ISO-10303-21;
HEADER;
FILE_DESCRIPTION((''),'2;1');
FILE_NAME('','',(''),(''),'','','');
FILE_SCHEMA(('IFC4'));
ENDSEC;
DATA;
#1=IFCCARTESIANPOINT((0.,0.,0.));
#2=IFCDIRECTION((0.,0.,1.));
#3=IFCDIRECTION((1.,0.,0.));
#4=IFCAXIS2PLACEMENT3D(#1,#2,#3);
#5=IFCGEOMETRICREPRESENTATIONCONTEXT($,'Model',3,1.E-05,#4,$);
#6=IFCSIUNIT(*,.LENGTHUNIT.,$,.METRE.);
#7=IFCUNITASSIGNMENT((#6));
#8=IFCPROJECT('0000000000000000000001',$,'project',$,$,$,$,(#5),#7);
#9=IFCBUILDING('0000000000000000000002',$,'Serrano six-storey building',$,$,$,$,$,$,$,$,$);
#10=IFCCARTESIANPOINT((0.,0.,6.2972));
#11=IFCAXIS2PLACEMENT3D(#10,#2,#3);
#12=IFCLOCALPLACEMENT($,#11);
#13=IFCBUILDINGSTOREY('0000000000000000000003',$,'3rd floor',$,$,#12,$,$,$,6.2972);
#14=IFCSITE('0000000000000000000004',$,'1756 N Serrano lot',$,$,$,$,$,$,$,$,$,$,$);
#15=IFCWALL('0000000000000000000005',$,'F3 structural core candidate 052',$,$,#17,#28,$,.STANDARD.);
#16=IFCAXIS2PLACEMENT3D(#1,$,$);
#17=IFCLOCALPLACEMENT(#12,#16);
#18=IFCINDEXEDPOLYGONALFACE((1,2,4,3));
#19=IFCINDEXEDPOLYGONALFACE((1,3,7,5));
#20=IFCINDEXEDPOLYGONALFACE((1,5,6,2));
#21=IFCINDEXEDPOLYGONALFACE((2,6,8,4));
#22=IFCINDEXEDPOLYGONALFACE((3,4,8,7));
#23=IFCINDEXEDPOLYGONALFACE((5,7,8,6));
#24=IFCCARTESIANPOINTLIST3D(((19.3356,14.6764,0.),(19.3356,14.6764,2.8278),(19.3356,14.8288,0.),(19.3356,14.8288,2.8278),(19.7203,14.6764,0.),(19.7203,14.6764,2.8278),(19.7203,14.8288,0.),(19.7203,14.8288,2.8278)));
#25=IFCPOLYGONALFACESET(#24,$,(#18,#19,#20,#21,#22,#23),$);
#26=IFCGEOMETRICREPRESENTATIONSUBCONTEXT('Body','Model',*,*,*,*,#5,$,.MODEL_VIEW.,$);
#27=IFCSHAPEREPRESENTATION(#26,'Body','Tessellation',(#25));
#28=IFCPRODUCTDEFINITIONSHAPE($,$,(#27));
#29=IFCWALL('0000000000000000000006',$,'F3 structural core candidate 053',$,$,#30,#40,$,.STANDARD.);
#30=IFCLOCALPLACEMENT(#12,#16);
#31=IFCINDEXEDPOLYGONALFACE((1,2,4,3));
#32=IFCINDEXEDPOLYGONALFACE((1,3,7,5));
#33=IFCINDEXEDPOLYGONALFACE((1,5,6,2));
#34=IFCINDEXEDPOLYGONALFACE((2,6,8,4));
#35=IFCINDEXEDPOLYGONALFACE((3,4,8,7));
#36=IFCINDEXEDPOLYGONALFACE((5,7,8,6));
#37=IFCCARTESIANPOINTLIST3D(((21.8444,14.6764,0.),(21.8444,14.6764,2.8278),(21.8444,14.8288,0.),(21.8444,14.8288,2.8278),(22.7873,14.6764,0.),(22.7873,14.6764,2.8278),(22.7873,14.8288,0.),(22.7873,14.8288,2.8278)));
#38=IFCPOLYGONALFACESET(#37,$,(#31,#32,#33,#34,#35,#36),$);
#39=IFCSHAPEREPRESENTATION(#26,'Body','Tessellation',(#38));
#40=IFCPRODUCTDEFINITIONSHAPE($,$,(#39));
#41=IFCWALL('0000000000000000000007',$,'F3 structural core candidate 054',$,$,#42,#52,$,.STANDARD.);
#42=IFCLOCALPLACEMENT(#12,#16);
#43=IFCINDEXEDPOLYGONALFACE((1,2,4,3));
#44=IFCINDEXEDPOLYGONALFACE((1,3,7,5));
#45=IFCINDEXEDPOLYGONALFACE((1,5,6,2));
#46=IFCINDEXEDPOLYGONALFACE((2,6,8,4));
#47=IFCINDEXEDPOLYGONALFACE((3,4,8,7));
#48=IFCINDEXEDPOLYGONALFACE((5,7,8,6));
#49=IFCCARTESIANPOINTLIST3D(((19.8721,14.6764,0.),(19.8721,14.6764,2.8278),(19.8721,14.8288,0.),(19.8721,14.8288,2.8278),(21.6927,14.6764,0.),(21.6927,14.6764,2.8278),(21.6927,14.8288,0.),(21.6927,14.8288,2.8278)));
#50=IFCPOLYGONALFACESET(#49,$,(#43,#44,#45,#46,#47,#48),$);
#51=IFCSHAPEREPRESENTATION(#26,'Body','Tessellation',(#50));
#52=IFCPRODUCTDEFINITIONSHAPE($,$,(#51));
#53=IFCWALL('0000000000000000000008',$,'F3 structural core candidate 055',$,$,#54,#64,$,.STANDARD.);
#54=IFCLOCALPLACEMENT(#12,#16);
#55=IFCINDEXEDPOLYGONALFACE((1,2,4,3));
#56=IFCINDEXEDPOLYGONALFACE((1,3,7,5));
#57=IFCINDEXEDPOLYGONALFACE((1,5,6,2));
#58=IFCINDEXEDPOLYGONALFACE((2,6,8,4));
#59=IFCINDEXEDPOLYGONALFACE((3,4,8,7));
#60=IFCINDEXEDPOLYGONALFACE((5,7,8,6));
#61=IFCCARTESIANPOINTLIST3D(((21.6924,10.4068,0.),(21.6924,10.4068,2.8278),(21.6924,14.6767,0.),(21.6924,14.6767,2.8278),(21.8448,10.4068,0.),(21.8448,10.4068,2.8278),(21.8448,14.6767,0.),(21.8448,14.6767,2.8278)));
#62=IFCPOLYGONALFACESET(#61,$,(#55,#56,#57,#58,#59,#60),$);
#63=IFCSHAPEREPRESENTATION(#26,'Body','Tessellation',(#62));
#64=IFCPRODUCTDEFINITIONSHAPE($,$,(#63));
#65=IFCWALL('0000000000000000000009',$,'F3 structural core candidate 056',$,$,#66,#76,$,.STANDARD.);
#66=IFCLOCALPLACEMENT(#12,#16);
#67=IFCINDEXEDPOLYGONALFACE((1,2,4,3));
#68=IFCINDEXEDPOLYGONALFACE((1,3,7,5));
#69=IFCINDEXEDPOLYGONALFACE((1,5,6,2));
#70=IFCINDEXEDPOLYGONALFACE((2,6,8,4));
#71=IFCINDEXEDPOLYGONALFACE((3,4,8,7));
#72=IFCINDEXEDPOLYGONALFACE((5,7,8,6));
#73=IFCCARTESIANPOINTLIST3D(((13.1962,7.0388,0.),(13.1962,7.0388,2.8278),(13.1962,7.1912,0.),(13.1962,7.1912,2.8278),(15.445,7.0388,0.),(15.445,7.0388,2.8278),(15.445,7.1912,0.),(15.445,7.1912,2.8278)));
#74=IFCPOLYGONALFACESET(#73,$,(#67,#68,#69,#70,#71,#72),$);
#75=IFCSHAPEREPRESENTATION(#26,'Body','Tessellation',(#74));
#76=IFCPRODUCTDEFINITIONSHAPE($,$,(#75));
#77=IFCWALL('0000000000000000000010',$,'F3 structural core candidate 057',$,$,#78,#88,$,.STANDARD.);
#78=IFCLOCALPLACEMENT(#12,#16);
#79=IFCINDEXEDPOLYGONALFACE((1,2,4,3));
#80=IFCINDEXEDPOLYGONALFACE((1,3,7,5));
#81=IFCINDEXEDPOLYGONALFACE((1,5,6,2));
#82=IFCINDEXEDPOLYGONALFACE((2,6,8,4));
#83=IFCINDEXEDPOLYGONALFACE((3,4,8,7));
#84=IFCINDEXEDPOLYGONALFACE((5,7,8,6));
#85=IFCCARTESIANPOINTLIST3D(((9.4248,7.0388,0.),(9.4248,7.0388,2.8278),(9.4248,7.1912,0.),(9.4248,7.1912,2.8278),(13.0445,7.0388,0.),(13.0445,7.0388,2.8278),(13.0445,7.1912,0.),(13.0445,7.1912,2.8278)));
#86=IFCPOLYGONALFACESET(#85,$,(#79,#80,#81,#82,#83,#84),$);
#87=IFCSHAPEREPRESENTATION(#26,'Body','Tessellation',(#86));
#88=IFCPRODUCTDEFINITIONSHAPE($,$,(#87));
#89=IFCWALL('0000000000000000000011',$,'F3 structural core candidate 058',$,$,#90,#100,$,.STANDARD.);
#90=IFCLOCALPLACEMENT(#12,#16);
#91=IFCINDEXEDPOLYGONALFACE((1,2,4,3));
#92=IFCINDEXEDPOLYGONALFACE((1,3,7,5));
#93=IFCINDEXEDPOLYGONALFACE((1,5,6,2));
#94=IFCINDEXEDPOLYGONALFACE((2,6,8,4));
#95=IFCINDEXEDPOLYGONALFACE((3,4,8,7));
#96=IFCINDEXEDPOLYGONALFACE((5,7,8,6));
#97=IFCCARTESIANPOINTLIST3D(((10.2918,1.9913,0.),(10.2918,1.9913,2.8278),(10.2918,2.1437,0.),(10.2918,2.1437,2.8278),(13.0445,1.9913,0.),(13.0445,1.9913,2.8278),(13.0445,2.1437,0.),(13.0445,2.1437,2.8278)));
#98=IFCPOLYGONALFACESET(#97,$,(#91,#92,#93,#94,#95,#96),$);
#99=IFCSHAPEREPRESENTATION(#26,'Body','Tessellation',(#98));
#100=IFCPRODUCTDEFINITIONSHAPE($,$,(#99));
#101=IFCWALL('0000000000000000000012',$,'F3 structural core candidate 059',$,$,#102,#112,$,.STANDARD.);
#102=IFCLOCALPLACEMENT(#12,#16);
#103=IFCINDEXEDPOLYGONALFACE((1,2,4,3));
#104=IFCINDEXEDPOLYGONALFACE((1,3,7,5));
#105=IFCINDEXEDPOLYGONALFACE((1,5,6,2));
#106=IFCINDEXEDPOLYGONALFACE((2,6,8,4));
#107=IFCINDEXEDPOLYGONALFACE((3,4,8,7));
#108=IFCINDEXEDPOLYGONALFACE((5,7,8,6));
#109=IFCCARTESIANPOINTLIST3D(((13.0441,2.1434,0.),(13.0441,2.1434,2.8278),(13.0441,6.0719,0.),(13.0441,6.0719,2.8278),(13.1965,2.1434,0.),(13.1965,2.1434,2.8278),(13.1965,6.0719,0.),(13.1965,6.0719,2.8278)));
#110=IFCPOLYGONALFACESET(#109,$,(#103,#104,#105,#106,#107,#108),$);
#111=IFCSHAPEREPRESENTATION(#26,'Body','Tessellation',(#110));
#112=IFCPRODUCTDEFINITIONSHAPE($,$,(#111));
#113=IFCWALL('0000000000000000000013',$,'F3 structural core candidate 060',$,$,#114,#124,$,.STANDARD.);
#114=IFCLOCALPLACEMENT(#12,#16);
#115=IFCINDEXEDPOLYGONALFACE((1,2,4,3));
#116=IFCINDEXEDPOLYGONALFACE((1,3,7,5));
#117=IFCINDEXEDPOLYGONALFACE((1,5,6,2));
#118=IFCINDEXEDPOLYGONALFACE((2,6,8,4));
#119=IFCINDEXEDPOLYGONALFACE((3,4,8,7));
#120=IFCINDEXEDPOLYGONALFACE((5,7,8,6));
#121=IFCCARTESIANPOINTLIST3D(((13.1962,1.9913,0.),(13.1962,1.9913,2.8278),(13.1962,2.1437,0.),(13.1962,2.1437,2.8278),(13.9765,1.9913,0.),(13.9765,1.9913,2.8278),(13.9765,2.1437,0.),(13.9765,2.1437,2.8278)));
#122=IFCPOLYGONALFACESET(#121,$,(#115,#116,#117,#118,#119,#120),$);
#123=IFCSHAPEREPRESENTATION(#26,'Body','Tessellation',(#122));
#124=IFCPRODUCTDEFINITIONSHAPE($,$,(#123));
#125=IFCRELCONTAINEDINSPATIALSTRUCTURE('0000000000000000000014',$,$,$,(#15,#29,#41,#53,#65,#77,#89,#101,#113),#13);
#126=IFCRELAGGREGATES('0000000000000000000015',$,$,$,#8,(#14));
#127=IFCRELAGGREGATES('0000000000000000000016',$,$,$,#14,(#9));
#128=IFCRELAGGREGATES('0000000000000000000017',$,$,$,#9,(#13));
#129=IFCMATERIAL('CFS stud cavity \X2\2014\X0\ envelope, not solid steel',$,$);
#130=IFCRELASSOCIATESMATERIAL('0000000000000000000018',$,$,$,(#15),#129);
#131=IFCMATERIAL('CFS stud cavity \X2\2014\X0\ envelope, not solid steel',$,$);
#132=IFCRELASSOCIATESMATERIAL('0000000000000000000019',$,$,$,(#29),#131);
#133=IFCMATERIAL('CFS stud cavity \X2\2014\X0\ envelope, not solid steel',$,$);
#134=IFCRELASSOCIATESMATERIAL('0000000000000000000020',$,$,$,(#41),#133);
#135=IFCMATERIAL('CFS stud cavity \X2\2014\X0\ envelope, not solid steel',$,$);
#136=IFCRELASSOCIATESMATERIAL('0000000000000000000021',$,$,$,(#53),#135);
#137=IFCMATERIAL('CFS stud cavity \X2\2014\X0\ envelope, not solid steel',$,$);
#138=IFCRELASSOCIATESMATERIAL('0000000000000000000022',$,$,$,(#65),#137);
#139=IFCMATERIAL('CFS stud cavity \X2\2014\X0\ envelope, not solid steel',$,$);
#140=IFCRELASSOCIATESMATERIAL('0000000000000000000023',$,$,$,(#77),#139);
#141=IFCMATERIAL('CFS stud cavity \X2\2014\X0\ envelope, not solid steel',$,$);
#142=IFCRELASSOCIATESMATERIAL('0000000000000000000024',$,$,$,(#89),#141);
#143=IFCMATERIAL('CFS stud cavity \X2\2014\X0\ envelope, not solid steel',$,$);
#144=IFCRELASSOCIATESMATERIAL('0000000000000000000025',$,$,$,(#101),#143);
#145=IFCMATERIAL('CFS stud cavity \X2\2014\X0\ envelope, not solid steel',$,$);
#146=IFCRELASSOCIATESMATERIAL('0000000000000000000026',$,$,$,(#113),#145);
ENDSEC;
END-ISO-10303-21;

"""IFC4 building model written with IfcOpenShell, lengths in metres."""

from ifc_helpers import new_model, si_unit, frame, origin_with_axes, place, context, subcontext, project, spatial, polyline, outline, extrude, material, element, save


model = new_model("IFC4")

# Units and contexts
model_context = context("Model", 3, precision=1e-05, world=origin_with_axes())
body_context = subcontext(model_context, "Body", "Model", "MODEL_VIEW")
ifc_project = project(units=[si_unit("LENGTHUNIT", "METRE")], contexts=[model_context])

# Site, building, storey
site = spatial("IfcSite", under=ifc_project, Name="1756 N Serrano lot")
building = spatial("IfcBuilding", under=site, Name="Serrano six-storey building")
storey_placement = place(None, frame((0.0, 0.0, 6.2972), z_axis=(0.0, 0.0, 1.0), x_axis=(1.0, 0.0, 0.0)))
storey = spatial("IfcBuildingStorey", under=building, at=storey_placement, Name="3rd floor", Elevation=6.2972)

# Walls
ifc_material_1 = material(Name="CFS stud cavity — envelope, not solid steel")
wall_1_placement = place(storey_placement, frame((0.0, 0.0, -6.2972), z_axis=(0.0, 0.0, 1.0), x_axis=(1.0, 0.0, 0.0)))
element("IfcWall", 1, at=wall_1_placement, inside=storey, material=ifc_material_1, Name="F3 structural core candidate 052", PredefinedType="STANDARD", context=body_context, shape_type="SweptSolid", body=[
    extrude(outline(polyline([(19.7203, 14.8288), (19.7203, 14.6764), (19.3356, 14.6764), (19.3356, 14.8288), (19.7203, 14.8288)])), frame((0.0, 0.0, 6.2972)), (0.0, 0.0, 1.0), 2.8278),
])
ifc_material_2 = material(Name="CFS stud cavity — envelope, not solid steel")
wall_2_placement = place(storey_placement, frame((0.0, 0.0, -6.2972), z_axis=(0.0, 0.0, 1.0), x_axis=(1.0, 0.0, 0.0)))
element("IfcWall", 2, at=wall_2_placement, inside=storey, material=ifc_material_2, Name="F3 structural core candidate 053", PredefinedType="STANDARD", context=body_context, shape_type="SweptSolid", body=[
    extrude(outline(polyline([(22.7873, 14.8288), (22.7873, 14.6764), (21.8444, 14.6764), (21.8444, 14.8288), (22.7873, 14.8288)])), frame((0.0, 0.0, 6.2972)), (0.0, 0.0, 1.0), 2.8278),
])
ifc_material_3 = material(Name="CFS stud cavity — envelope, not solid steel")
wall_3_placement = place(storey_placement, frame((0.0, 0.0, -6.2972), z_axis=(0.0, 0.0, 1.0), x_axis=(1.0, 0.0, 0.0)))
element("IfcWall", 3, at=wall_3_placement, inside=storey, material=ifc_material_3, Name="F3 structural core candidate 054", PredefinedType="STANDARD", context=body_context, shape_type="SweptSolid", body=[
    extrude(outline(polyline([(21.6927, 14.8288), (21.6927, 14.6764), (19.8721, 14.6764), (19.8721, 14.8288), (21.6927, 14.8288)])), frame((0.0, 0.0, 6.2972)), (0.0, 0.0, 1.0), 2.8278),
])
ifc_material_4 = material(Name="CFS stud cavity — envelope, not solid steel")
wall_4_placement = place(storey_placement, frame((0.0, 0.0, -6.2972), z_axis=(0.0, 0.0, 1.0), x_axis=(1.0, 0.0, 0.0)))
element("IfcWall", 4, at=wall_4_placement, inside=storey, material=ifc_material_4, Name="F3 structural core candidate 055", PredefinedType="STANDARD", context=body_context, shape_type="SweptSolid", body=[
    extrude(outline(polyline([(21.8448, 10.4068), (21.6924, 10.4068), (21.6924, 14.6767), (21.8448, 14.6767), (21.8448, 10.4068)])), frame((0.0, 0.0, 6.2972)), (0.0, 0.0, 1.0), 2.8278),
])
ifc_material_5 = material(Name="CFS stud cavity — envelope, not solid steel")
wall_5_placement = place(storey_placement, frame((0.0, 0.0, -6.2972), z_axis=(0.0, 0.0, 1.0), x_axis=(1.0, 0.0, 0.0)))
element("IfcWall", 5, at=wall_5_placement, inside=storey, material=ifc_material_5, Name="F3 structural core candidate 056", PredefinedType="STANDARD", context=body_context, shape_type="SweptSolid", body=[
    extrude(outline(polyline([(15.445, 7.1912), (15.445, 7.0388), (13.1962, 7.0388), (13.1962, 7.1912), (15.445, 7.1912)])), frame((0.0, 0.0, 6.2972)), (0.0, 0.0, 1.0), 2.8278),
])
ifc_material_6 = material(Name="CFS stud cavity — envelope, not solid steel")
wall_6_placement = place(storey_placement, frame((0.0, 0.0, -6.2972), z_axis=(0.0, 0.0, 1.0), x_axis=(1.0, 0.0, 0.0)))
element("IfcWall", 6, at=wall_6_placement, inside=storey, material=ifc_material_6, Name="F3 structural core candidate 057", PredefinedType="STANDARD", context=body_context, shape_type="SweptSolid", body=[
    extrude(outline(polyline([(13.0445, 7.1912), (13.0445, 7.0388), (9.4248, 7.0388), (9.4248, 7.1912), (13.0445, 7.1912)])), frame((0.0, 0.0, 6.2972)), (0.0, 0.0, 1.0), 2.8278),
])
ifc_material_7 = material(Name="CFS stud cavity — envelope, not solid steel")
wall_7_placement = place(storey_placement, frame((0.0, 0.0, -6.2972), z_axis=(0.0, 0.0, 1.0), x_axis=(1.0, 0.0, 0.0)))
element("IfcWall", 7, at=wall_7_placement, inside=storey, material=ifc_material_7, Name="F3 structural core candidate 058", PredefinedType="STANDARD", context=body_context, shape_type="SweptSolid", body=[
    extrude(outline(polyline([(13.0445, 2.1437), (13.0445, 1.9913), (10.2918, 1.9913), (10.2918, 2.1437), (13.0445, 2.1437)])), frame((0.0, 0.0, 6.2972)), (0.0, 0.0, 1.0), 2.8278),
])
ifc_material_8 = material(Name="CFS stud cavity — envelope, not solid steel")
wall_8_placement = place(storey_placement, frame((0.0, 0.0, -6.2972), z_axis=(0.0, 0.0, 1.0), x_axis=(1.0, 0.0, 0.0)))
element("IfcWall", 8, at=wall_8_placement, inside=storey, material=ifc_material_8, Name="F3 structural core candidate 059", PredefinedType="STANDARD", context=body_context, shape_type="SweptSolid", body=[
    extrude(outline(polyline([(13.1965, 2.1434), (13.0441, 2.1434), (13.0441, 6.0719), (13.1965, 6.0719), (13.1965, 2.1434)])), frame((0.0, 0.0, 6.2972)), (0.0, 0.0, 1.0), 2.8278),
])
ifc_material_9 = material(Name="CFS stud cavity — envelope, not solid steel")
wall_9_placement = place(storey_placement, frame((0.0, 0.0, -6.2972), z_axis=(0.0, 0.0, 1.0), x_axis=(1.0, 0.0, 0.0)))
element("IfcWall", 9, at=wall_9_placement, inside=storey, material=ifc_material_9, Name="F3 structural core candidate 060", PredefinedType="STANDARD", context=body_context, shape_type="SweptSolid", body=[
    extrude(outline(polyline([(13.9765, 2.1437), (13.9765, 1.9913), (13.1962, 1.9913), (13.1962, 2.1437), (13.9765, 2.1437)])), frame((0.0, 0.0, 6.2972)), (0.0, 0.0, 1.0), 2.8278),
])

save(model, "model.ifc")
